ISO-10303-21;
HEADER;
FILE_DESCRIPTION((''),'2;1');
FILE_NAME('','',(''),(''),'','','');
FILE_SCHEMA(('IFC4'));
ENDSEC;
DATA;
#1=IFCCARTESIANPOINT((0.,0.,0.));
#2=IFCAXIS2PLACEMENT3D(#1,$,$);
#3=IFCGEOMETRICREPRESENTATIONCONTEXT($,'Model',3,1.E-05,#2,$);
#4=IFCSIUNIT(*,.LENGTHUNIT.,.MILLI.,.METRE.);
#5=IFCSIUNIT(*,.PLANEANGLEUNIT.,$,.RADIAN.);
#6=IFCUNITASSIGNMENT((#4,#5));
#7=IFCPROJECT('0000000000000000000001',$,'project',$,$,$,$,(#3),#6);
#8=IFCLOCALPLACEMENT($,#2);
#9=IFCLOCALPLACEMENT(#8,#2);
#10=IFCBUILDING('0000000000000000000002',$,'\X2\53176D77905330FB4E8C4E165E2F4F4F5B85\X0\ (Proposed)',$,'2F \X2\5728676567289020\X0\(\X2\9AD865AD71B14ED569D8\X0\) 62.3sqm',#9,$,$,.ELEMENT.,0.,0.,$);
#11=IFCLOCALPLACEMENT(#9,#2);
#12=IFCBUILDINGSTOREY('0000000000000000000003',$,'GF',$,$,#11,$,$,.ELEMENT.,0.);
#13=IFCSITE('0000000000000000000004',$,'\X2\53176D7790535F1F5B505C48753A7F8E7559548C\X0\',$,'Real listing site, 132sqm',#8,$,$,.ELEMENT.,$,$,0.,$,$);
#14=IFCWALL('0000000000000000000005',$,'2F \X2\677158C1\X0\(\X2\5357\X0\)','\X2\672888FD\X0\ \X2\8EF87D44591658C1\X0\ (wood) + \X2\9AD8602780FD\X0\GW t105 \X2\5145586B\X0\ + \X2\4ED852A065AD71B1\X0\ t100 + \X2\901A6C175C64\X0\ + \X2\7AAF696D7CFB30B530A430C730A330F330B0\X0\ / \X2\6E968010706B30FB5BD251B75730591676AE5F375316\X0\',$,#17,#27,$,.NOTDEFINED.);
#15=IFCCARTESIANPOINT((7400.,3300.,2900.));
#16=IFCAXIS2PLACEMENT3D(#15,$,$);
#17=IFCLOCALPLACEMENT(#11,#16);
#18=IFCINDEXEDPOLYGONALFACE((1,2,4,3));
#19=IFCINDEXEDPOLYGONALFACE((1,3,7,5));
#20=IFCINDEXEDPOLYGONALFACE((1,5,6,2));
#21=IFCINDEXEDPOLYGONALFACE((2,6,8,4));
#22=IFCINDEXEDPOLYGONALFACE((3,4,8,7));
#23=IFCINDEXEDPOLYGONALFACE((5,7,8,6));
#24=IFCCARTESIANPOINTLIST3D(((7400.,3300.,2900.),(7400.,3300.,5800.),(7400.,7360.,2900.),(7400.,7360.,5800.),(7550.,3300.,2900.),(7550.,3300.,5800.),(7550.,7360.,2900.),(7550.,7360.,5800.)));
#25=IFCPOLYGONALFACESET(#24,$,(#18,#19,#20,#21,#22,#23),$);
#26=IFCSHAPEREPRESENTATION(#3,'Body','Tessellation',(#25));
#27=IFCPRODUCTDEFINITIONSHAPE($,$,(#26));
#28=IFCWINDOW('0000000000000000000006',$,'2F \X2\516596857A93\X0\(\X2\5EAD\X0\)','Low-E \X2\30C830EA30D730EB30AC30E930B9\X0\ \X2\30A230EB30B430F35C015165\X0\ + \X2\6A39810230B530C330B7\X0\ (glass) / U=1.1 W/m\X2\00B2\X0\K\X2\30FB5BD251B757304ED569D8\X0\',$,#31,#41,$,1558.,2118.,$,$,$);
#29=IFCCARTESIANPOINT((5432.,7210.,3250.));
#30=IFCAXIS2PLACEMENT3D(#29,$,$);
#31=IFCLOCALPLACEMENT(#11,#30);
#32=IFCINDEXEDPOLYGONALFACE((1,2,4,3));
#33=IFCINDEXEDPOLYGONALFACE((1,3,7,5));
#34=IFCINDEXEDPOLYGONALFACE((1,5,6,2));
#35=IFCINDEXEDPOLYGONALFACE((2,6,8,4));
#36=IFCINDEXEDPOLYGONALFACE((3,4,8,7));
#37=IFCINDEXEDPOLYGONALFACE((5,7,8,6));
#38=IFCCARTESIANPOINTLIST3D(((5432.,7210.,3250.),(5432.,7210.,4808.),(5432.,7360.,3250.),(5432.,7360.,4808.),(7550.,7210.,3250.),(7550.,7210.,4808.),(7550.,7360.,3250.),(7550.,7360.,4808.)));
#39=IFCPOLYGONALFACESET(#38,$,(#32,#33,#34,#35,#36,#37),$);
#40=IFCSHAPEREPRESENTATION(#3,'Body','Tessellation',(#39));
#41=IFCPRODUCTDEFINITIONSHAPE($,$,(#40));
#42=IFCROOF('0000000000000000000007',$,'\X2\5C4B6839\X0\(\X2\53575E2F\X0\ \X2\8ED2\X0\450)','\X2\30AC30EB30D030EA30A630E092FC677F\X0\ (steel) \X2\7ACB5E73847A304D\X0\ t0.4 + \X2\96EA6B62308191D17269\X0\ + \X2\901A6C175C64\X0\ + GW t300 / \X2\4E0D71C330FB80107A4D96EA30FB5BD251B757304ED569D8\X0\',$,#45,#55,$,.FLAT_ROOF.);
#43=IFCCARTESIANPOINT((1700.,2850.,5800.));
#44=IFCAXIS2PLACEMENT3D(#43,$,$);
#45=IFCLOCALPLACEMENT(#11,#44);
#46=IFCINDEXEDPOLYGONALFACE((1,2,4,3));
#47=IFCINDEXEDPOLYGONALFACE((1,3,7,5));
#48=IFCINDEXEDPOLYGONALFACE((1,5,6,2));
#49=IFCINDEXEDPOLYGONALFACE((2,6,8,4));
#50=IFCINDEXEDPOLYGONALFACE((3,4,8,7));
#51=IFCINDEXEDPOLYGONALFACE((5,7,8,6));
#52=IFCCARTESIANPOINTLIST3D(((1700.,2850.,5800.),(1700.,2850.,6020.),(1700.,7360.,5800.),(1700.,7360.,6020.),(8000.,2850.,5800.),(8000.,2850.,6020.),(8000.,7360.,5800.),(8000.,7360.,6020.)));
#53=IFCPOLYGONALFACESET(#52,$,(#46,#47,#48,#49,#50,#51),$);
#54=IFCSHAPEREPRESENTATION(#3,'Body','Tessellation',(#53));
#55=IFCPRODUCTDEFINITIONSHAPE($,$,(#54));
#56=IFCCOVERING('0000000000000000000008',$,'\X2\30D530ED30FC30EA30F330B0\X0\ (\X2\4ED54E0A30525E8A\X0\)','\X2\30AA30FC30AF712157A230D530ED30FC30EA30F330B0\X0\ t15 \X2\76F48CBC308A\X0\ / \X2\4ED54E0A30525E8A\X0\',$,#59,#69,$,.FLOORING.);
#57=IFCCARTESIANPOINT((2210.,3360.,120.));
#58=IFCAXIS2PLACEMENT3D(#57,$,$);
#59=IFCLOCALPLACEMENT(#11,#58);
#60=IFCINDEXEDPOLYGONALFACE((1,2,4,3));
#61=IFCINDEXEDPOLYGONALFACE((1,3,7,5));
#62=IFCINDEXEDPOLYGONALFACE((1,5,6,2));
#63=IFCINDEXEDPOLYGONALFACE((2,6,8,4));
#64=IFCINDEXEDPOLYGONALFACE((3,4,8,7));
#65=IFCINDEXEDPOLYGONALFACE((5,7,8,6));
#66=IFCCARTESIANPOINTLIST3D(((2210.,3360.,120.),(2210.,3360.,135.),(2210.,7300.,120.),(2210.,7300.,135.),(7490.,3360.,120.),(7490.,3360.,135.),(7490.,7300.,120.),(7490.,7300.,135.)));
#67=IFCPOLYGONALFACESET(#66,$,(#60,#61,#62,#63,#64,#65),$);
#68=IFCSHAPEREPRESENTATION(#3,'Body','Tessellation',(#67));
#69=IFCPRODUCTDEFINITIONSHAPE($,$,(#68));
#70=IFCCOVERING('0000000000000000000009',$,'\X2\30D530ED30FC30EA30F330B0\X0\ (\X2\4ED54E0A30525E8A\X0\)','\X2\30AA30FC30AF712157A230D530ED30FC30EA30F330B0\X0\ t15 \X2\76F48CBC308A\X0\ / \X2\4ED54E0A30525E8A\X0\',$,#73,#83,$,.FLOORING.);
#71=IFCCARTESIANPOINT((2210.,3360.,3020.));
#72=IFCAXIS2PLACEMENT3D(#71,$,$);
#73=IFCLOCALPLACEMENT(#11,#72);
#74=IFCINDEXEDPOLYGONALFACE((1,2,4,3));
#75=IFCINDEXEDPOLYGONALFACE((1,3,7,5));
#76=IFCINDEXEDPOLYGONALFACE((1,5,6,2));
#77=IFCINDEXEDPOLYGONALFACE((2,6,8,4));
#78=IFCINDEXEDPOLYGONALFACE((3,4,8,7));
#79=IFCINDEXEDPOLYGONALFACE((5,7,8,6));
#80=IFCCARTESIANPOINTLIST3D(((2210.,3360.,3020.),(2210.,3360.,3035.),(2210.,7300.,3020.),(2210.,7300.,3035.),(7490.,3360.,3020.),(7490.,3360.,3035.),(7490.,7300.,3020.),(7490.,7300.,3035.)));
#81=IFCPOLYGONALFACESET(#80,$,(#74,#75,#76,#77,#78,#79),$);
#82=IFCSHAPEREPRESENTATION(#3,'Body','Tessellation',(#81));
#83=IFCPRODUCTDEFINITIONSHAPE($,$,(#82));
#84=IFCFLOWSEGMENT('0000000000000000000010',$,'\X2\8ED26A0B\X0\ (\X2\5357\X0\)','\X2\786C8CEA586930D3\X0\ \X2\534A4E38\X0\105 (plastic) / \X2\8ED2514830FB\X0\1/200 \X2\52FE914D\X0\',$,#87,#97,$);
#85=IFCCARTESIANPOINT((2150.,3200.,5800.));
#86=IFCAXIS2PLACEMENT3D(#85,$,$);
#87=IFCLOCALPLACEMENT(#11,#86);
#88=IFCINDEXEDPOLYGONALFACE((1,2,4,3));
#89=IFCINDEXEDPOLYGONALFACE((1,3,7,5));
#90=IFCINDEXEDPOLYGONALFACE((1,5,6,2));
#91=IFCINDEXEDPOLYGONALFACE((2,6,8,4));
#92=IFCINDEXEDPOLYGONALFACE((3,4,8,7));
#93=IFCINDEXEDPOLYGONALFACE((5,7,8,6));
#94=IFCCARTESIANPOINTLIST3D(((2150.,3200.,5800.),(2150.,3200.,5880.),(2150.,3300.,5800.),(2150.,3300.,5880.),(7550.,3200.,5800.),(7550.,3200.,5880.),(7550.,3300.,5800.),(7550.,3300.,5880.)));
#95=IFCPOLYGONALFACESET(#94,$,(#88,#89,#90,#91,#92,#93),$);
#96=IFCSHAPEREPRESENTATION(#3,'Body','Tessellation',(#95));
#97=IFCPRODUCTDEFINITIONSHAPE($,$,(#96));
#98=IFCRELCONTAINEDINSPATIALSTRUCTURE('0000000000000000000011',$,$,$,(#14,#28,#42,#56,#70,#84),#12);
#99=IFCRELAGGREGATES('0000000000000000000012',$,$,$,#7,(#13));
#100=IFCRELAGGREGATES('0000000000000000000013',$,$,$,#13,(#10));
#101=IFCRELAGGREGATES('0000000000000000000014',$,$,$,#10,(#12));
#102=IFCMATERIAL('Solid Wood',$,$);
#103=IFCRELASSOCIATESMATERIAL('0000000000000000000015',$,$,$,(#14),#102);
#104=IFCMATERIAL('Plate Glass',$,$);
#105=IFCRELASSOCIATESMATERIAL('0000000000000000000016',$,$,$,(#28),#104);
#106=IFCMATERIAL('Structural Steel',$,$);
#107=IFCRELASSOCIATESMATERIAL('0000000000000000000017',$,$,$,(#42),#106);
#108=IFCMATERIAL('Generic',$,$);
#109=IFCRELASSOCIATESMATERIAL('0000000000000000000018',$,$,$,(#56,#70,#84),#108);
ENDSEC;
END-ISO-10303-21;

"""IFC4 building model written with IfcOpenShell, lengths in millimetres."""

from ifc_helpers import new_model, si_unit, frame, frame_2d, origin, place, context, project, spatial, rectangle, extrude, material, element, fill, save


model = new_model("IFC4")

# Units and contexts
model_context = context("Model", 3, precision=1e-05, world=origin())
ifc_project = project(units=[si_unit("LENGTHUNIT", "METRE", prefix="MILLI"), si_unit("PLANEANGLEUNIT", "RADIAN")], contexts=[model_context])

# Site, building, storey
site_placement = place(None, origin())
site = spatial("IfcSite", under=ifc_project, at=site_placement, Name="北海道弟子屈町美留和", ObjectType="Real listing site, 132sqm", CompositionType="ELEMENT", RefElevation=0.0)
building_placement = place(site_placement, origin())
building = spatial("IfcBuilding", under=site, at=building_placement, Name="北海道・二世帯住宅 (Proposed)", ObjectType="2F 在来木造(高断熱仕様) 62.3sqm", CompositionType="ELEMENT", ElevationOfRefHeight=0.0, ElevationOfTerrain=0.0)
storey_placement = place(building_placement, origin())
storey = spatial("IfcBuildingStorey", under=building, at=storey_placement, Name="GF", CompositionType="ELEMENT", Elevation=0.0)

# Shared definitions
ifc_material_1 = material(Name="Solid Wood")

# Shared definitions
ifc_material_2 = material(Name="Plate Glass")

# Wall, opening, window
wall_1_placement = place(storey_placement, frame((7400.0, 3300.0, 2900.0)))
wall_1 = element("IfcWall", 1, at=wall_1_placement, inside=storey, material=ifc_material_1, Name="2F 東壁(南)", Description="木製 軸組外壁 (wood) + 高性能GW t105 充填 + 付加断熱 t100 + 通気層 + 窯業系サイディング / 準耐火・寒冷地外皮強化", PredefinedType="NOTDEFINED", context=model_context, shape_type="SweptSolid", body=[
    extrude(rectangle(XDim=150.0, YDim=4060.0, at=frame_2d((75.0, 2030.0))), frame((7400.0, 3300.0, 2900.0)), (0.0, 0.0, 1.0), 2900.0),
])
opening_1_placement = place(storey_placement, frame((5432.0, 7210.0, 3250.0)))
opening_1 = element("IfcOpeningElement", 2, at=opening_1_placement, cuts=wall_1, PredefinedType="NOTDEFINED", context=model_context, shape_type="SweptSolid", body=[
    extrude(rectangle(XDim=2118.0, YDim=150.0, at=frame_2d((1059.0, 75.0))), frame((5432.0, 7210.0, 3250.0)), (0.0, 0.0, 1.0), 1558.0),
])
window_1_placement = place(storey_placement, frame((5432.0, 7210.0, 3250.0)))
window_1 = element("IfcWindow", 3, at=window_1_placement, inside=storey, material=ifc_material_2, Name="2F 入隅窓(庭)", Description="Low-E トリプルガラス アルゴン封入 + 樹脂サッシ (glass) / U=1.1 W/m²K・寒冷地仕様", OverallHeight=1558.0, OverallWidth=2118.0, context=model_context, shape_type="SweptSolid", body=[
    extrude(rectangle(XDim=2118.0, YDim=150.0, at=frame_2d((1059.0, 75.0))), frame((5432.0, 7210.0, 3250.0)), (0.0, 0.0, 1.0), 1558.0),
])
fill(opening_1, window_1)

# Roof
ifc_material_3 = material(Name="Structural Steel")
for number, where, name in (
    (4, (1700.0, 2850.0, 5800.0), "屋根(南帯 軒450)"),
):
    element("IfcRoof", number, at=place(storey_placement, frame(where)), inside=storey, material=ifc_material_3, Name=name, Description="ガルバリウム鋼板 (steel) 立平葺き t0.4 + 雪止め金物 + 通気層 + GW t300 / 不燃・耐積雪・寒冷地仕様", PredefinedType="FLAT_ROOF", context=model_context, shape_type="SweptSolid", body=[
        extrude(rectangle(XDim=6300.0, YDim=4510.0, at=frame_2d((3150.0, 2255.0))), frame((1700.0, 2850.0, 5800.0)), (0.0, 0.0, 1.0), 220.0),
    ])

# Coverings
ifc_material_4 = material(Name="Generic")
covering_1_placement = place(storey_placement, frame((2210.0, 3360.0, 120.0)))
element("IfcCovering", 5, at=covering_1_placement, inside=storey, material=ifc_material_4, Name="フローリング (仕上げ床)", Description="オーク無垢フローリング t15 直貼り / 仕上げ床", PredefinedType="FLOORING", context=model_context, shape_type="SweptSolid", body=[
    extrude(rectangle(XDim=5280.0, YDim=3940.0, at=frame_2d((2640.0, 1970.0))), frame((2210.0, 3360.0, 120.0)), (0.0, 0.0, 1.0), 15.0),
])
covering_2_placement = place(storey_placement, frame((2210.0, 3360.0, 3020.0)))
element("IfcCovering", 6, at=covering_2_placement, inside=storey, material=ifc_material_4, Name="フローリング (仕上げ床)", Description="オーク無垢フローリング t15 直貼り / 仕上げ床", PredefinedType="FLOORING", context=model_context, shape_type="SweptSolid", body=[
    extrude(rectangle(XDim=5280.0, YDim=3940.0, at=frame_2d((2640.0, 1970.0))), frame((2210.0, 3360.0, 3020.0)), (0.0, 0.0, 1.0), 15.0),
])

# Flow segment
flow_segment_placement = place(storey_placement, frame((2150.0, 3200.0, 5800.0)))
element("IfcFlowSegment", 7, at=flow_segment_placement, inside=storey, material=ifc_material_4, Name="軒樋 (南)", Description="硬質塩ビ 半丸105 (plastic) / 軒先・1/200 勾配", context=model_context, shape_type="SweptSolid", body=[
    extrude(rectangle(XDim=5400.0, YDim=100.0, at=frame_2d((2700.0, 50.0))), frame((2150.0, 3200.0, 5800.0)), (0.0, 0.0, 1.0), 80.0),
])

save(model, "model.ifc")
